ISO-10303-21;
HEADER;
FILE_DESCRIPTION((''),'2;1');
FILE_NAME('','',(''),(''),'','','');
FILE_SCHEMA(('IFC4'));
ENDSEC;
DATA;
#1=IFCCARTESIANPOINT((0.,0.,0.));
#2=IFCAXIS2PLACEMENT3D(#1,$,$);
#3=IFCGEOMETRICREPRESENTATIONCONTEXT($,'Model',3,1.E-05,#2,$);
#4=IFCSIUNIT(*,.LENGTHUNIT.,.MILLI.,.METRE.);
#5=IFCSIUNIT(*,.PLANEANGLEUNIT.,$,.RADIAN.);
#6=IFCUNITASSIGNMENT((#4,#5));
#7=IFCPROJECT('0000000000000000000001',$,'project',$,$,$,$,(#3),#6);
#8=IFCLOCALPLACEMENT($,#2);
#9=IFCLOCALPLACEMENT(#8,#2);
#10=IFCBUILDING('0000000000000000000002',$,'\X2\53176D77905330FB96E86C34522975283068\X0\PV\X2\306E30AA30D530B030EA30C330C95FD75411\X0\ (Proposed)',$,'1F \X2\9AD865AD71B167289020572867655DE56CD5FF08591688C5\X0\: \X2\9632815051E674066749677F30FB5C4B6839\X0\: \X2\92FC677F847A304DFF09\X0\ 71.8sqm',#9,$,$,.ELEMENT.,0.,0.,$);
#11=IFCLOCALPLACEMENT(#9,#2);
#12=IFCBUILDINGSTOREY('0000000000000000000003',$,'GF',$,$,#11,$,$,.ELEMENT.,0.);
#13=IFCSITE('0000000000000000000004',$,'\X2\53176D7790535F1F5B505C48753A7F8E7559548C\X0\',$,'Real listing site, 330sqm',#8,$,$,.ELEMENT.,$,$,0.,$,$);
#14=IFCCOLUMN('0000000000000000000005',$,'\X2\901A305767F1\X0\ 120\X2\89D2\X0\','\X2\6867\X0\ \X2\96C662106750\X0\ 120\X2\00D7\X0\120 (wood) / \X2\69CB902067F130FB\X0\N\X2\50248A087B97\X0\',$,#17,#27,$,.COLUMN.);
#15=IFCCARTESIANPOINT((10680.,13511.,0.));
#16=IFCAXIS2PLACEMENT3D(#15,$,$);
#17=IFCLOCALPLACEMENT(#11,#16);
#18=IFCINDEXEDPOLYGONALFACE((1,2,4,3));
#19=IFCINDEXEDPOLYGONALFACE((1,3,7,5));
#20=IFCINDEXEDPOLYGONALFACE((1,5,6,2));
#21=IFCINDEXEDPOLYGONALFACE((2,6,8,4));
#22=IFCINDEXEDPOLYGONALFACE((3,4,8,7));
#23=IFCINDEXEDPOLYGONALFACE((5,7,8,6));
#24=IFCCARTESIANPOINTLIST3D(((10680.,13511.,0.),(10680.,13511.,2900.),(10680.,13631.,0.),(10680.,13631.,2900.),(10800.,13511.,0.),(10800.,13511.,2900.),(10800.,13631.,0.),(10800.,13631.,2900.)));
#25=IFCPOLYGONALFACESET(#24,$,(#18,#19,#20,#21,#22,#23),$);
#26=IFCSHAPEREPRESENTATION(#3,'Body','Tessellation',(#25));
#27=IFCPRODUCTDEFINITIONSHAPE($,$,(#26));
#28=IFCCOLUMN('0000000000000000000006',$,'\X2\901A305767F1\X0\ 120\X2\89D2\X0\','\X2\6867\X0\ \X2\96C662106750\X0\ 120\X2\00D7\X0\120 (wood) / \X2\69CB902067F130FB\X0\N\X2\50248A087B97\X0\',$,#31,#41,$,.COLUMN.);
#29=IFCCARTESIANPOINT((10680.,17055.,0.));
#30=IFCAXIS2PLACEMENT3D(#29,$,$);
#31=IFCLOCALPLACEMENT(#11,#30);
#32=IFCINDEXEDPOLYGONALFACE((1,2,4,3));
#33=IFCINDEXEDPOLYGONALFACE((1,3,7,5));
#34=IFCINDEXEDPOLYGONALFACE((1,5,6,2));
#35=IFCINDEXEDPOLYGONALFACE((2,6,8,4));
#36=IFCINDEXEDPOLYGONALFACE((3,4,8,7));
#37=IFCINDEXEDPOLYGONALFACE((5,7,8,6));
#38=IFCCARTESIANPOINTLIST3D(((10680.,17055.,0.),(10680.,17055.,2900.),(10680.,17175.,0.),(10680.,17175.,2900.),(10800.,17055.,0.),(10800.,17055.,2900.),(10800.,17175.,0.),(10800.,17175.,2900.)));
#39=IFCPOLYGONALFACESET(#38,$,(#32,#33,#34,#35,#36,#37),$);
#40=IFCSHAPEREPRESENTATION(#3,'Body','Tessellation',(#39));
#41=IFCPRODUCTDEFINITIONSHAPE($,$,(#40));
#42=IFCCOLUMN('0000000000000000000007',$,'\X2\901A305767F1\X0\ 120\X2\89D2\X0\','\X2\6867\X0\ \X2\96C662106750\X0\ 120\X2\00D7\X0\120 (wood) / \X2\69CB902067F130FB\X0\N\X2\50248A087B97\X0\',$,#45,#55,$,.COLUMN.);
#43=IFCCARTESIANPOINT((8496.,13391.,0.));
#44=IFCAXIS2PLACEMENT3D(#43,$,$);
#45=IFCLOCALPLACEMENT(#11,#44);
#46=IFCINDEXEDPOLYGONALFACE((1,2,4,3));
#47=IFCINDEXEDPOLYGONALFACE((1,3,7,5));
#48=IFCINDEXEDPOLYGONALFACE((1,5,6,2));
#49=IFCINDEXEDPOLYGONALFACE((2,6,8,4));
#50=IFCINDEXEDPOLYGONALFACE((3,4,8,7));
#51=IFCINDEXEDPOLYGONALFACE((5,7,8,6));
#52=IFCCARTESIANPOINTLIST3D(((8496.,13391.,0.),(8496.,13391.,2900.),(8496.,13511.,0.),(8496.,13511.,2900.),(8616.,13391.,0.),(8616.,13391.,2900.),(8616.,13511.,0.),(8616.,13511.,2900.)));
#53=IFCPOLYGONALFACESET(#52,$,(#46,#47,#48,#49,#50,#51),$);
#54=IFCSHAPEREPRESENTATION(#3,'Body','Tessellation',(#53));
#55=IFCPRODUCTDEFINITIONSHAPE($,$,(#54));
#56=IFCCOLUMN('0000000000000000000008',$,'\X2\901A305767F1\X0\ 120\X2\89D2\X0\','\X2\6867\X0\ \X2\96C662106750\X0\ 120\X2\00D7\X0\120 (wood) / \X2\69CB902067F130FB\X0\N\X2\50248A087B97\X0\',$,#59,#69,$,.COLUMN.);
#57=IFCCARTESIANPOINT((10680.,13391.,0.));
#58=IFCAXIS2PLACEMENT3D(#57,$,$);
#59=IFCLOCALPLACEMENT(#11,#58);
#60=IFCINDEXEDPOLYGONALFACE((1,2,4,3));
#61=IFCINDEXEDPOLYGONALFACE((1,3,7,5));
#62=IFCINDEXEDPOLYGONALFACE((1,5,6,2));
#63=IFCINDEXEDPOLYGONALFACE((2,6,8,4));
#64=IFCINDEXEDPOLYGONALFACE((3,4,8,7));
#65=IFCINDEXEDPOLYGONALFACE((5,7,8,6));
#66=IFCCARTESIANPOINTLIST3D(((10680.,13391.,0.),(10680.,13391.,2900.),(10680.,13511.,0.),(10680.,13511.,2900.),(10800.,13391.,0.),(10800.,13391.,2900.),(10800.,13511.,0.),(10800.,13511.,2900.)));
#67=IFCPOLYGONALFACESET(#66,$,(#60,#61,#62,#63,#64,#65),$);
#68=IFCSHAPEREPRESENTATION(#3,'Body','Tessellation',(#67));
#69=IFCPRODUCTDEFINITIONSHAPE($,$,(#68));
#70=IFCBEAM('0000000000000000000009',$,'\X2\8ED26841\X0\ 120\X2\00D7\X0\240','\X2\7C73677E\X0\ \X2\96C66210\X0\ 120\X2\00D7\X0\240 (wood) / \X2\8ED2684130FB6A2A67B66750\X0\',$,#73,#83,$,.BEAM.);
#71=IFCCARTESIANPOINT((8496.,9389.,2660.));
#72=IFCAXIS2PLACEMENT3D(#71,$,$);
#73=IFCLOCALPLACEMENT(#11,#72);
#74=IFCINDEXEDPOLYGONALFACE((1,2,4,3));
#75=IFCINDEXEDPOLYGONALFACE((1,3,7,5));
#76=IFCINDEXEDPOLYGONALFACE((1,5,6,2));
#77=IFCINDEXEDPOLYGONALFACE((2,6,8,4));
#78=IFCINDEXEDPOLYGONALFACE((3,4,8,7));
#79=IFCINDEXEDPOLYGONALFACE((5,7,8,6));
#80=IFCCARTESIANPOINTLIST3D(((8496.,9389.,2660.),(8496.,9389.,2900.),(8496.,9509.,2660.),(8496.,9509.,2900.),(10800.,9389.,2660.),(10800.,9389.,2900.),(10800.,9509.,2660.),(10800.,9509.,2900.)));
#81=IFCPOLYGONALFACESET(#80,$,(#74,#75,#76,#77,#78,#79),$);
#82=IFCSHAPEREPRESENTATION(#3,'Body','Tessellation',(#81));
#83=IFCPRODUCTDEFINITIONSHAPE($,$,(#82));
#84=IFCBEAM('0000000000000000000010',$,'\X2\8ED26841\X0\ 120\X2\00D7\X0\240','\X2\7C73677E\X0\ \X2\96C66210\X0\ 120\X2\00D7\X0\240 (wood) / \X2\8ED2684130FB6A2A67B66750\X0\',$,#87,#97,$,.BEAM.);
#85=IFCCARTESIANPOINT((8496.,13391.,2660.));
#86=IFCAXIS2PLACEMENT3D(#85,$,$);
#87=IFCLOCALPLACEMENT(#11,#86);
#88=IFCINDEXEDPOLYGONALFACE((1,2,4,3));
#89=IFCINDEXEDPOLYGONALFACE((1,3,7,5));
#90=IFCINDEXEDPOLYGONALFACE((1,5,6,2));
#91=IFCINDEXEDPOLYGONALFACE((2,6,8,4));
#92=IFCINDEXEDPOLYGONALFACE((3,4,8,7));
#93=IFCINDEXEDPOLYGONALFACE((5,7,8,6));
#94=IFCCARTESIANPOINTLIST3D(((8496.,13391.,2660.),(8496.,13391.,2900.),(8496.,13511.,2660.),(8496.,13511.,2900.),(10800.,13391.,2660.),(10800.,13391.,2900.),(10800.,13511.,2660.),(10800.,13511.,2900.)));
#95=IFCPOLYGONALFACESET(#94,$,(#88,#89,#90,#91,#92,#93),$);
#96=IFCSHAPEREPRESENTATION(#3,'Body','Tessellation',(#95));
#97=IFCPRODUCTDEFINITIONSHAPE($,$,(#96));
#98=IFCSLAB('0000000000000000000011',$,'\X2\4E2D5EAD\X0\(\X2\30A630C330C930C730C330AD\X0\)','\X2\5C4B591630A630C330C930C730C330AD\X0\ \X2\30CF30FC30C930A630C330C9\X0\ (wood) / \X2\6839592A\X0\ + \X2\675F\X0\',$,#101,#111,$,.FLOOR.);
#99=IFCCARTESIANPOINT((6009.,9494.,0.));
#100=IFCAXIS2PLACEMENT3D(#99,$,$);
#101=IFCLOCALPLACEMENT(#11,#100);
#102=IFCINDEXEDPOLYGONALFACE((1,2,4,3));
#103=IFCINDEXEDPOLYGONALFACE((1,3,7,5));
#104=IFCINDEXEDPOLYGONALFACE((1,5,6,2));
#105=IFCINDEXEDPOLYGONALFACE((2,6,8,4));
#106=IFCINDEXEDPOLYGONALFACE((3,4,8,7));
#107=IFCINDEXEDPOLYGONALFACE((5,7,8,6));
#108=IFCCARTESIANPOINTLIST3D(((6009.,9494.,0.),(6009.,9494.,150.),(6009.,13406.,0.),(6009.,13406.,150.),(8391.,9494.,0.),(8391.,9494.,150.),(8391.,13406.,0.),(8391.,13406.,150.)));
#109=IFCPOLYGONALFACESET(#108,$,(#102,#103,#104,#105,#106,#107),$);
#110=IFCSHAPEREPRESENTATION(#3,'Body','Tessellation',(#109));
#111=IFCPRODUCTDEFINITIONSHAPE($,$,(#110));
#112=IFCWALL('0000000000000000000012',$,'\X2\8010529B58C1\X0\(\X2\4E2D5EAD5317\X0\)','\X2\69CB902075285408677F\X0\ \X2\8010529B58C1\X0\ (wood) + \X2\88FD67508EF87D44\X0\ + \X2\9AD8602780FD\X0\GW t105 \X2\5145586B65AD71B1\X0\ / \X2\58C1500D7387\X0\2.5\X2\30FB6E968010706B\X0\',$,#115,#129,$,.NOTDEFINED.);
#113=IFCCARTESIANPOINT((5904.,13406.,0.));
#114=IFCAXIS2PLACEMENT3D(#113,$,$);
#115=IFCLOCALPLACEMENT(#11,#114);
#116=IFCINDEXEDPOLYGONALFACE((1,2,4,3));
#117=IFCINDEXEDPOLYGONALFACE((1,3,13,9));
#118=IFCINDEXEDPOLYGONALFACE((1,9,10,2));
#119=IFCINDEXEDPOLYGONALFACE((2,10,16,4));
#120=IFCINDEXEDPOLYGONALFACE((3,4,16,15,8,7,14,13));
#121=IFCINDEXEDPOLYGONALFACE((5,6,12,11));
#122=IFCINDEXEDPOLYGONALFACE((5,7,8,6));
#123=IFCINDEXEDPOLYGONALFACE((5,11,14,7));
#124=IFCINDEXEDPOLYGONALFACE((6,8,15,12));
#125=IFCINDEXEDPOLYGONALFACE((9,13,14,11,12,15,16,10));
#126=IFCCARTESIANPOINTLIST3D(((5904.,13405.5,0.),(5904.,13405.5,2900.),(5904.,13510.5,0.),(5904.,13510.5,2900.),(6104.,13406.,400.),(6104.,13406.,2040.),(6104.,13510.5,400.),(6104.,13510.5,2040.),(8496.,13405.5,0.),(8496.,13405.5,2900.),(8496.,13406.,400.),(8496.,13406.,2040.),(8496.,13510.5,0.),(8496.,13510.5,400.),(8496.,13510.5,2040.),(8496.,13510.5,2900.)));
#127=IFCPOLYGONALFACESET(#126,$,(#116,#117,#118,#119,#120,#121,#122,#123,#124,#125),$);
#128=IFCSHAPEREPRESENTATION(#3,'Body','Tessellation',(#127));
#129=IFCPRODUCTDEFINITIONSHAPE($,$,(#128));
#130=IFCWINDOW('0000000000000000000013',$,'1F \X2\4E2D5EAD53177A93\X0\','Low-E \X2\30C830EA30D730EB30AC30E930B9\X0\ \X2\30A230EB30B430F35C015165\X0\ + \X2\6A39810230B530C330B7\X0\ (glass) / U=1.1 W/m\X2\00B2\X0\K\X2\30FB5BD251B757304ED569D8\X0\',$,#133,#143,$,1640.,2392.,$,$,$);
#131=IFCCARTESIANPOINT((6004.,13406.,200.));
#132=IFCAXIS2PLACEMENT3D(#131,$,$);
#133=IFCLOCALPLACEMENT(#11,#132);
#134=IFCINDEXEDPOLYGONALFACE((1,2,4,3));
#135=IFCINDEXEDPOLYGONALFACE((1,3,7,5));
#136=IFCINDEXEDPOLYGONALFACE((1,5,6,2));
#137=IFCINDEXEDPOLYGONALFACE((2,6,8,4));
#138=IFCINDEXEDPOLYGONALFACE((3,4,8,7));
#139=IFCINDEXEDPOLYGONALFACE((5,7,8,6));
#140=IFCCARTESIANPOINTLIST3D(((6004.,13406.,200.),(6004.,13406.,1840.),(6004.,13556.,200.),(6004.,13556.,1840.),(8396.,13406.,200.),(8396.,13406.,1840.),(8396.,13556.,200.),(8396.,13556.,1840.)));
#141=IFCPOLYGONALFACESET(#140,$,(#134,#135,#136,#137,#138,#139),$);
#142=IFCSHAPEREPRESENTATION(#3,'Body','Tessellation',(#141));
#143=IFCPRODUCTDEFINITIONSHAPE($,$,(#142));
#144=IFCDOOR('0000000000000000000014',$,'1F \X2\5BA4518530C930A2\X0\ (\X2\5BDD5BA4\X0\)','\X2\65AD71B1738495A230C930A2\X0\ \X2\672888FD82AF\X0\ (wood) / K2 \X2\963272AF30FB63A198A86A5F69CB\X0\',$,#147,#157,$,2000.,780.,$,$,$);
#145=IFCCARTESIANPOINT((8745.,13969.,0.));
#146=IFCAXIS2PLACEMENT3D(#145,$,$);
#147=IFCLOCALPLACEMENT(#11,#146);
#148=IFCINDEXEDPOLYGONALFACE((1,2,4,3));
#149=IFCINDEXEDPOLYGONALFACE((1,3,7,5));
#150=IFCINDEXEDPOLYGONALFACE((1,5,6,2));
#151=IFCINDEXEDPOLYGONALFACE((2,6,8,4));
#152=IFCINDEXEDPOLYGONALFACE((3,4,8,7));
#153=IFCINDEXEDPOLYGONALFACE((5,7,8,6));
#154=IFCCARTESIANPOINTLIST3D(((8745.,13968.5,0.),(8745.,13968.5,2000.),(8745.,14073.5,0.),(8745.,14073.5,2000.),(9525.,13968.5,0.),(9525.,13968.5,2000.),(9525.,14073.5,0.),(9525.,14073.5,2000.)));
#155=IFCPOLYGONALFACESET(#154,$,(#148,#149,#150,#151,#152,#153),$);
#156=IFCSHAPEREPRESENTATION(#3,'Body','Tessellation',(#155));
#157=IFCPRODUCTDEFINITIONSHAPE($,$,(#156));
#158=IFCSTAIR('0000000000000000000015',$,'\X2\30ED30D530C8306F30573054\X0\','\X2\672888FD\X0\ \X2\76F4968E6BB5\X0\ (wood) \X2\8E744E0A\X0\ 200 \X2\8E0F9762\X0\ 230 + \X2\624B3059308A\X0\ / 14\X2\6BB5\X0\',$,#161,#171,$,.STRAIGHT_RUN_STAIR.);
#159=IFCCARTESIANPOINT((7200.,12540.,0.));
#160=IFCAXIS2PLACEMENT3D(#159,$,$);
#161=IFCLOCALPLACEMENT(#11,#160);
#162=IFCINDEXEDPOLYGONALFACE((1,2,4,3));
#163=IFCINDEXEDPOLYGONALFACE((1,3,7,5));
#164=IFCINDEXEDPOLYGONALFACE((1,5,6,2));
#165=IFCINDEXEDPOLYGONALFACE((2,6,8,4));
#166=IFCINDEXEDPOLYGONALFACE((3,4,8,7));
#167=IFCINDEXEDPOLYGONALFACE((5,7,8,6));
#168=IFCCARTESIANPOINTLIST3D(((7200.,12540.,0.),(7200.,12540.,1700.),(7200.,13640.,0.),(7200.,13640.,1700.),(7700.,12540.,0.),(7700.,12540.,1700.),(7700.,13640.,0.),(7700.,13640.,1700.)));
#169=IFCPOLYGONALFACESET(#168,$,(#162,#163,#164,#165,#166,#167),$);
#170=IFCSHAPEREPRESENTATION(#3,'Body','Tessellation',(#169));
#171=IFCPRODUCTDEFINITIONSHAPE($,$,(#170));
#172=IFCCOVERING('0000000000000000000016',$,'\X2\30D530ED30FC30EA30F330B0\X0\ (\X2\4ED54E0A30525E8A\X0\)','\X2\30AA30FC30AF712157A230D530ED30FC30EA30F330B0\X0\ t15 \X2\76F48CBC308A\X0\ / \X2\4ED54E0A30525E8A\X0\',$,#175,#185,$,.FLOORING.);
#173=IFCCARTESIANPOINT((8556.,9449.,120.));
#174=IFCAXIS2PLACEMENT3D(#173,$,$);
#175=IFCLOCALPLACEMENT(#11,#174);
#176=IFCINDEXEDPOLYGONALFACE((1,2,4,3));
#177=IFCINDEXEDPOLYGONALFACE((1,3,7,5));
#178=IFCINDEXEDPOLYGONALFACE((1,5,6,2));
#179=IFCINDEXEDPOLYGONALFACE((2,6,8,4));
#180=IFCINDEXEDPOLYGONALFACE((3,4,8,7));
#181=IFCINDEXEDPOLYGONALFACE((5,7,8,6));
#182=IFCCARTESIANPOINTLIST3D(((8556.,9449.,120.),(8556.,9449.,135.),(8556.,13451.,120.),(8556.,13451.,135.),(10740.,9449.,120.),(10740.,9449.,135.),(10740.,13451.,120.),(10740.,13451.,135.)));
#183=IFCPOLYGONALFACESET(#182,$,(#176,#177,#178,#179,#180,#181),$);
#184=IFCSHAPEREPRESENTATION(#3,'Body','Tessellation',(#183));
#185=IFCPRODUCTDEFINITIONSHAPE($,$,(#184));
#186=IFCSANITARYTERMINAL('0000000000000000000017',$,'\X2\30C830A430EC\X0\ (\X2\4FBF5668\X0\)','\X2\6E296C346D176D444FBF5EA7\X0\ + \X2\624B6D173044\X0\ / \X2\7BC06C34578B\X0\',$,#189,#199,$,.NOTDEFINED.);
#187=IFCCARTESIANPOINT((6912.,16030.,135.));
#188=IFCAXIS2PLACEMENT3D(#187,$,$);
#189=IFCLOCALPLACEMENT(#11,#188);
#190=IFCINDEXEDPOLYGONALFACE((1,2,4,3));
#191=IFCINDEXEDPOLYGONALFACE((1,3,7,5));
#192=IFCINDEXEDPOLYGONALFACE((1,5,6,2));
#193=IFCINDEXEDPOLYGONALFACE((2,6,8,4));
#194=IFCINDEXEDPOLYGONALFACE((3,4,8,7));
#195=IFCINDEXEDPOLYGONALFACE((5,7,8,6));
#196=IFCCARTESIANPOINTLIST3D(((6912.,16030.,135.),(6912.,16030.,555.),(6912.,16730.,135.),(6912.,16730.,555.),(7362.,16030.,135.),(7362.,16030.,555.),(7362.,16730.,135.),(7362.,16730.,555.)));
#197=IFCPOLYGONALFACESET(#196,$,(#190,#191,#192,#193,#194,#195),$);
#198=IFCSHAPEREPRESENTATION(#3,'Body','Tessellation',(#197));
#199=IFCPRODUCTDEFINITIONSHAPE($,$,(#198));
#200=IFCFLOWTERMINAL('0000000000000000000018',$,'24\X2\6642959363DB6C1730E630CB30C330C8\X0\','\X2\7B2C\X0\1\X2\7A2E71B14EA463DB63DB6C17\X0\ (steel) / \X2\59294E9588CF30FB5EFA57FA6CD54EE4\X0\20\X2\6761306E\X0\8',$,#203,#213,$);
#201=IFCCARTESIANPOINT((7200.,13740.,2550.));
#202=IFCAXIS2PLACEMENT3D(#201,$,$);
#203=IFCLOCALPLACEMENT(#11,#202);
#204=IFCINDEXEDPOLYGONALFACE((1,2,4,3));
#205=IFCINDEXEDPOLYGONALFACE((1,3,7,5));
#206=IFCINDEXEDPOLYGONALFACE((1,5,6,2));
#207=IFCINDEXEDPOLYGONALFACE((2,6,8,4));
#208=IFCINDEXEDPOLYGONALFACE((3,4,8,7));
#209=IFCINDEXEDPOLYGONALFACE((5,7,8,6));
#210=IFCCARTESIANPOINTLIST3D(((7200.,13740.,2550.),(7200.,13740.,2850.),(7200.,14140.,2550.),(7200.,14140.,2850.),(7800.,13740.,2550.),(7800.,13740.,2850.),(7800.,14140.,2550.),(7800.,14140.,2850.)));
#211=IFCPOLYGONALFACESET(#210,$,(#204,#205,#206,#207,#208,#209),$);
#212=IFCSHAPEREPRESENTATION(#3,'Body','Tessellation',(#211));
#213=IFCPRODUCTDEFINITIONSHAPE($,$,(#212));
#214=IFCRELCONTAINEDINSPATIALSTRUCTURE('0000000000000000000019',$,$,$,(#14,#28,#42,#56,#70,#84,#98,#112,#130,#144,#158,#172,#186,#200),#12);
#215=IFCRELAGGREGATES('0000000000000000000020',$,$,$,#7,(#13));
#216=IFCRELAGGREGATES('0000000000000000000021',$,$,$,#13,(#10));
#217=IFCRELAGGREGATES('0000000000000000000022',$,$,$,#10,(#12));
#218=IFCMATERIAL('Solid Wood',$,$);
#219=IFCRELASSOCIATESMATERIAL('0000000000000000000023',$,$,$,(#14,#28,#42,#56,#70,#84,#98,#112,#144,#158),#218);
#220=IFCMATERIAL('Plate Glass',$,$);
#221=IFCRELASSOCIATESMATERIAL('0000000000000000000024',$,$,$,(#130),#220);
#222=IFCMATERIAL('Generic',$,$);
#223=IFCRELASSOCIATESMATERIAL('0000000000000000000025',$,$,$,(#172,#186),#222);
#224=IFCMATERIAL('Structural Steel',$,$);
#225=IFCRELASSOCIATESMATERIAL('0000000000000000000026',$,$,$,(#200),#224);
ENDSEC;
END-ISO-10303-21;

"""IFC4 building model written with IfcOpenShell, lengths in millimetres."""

from ifc_helpers import new_model, si_unit, frame, frame_2d, origin, place, context, project, spatial, rectangle, extrude, material, element, fill, save


model = new_model("IFC4")

# Units and contexts
model_context = context("Model", 3, precision=1e-05, world=origin())
ifc_project = project(units=[si_unit("LENGTHUNIT", "METRE", prefix="MILLI"), si_unit("PLANEANGLEUNIT", "RADIAN")], contexts=[model_context])

# Site, building, storey
site_placement = place(None, origin())
site = spatial("IfcSite", under=ifc_project, at=site_placement, Name="北海道弟子屈町美留和", ObjectType="Real listing site, 330sqm", CompositionType="ELEMENT", RefElevation=0.0)
building_placement = place(site_placement, origin())
building = spatial("IfcBuilding", under=site, at=building_placement, Name="北海道・雨水利用とPVのオフグリッド志向 (Proposed)", ObjectType="1F 高断熱木造在来工法（外装: 防腐処理杉板・屋根: 鋼板葺き） 71.8sqm", CompositionType="ELEMENT", ElevationOfRefHeight=0.0, ElevationOfTerrain=0.0)
storey_placement = place(building_placement, origin())
storey = spatial("IfcBuildingStorey", under=building, at=storey_placement, Name="GF", CompositionType="ELEMENT", Elevation=0.0)

# Columns
ifc_material_1 = material(Name="Solid Wood")
column_1_placement = place(storey_placement, frame((10680.0, 13511.0, 0.0)))
element("IfcColumn", 1, at=column_1_placement, inside=storey, material=ifc_material_1, Name="通し柱 120角", Description="桧 集成材 120×120 (wood) / 構造柱・N値計算", PredefinedType="COLUMN", context=model_context, shape_type="SweptSolid", body=[
    extrude(rectangle(XDim=120.0, YDim=120.0, at=frame_2d((60.0, 60.0))), frame((10680.0, 13511.0, 0.0)), (0.0, 0.0, 1.0), 2900.0),
])
column_2_placement = place(storey_placement, frame((10680.0, 17055.0, 0.0)))
element("IfcColumn", 2, at=column_2_placement, inside=storey, material=ifc_material_1, Name="通し柱 120角", Description="桧 集成材 120×120 (wood) / 構造柱・N値計算", PredefinedType="COLUMN", context=model_context, shape_type="SweptSolid", body=[
    extrude(rectangle(XDim=120.0, YDim=120.0, at=frame_2d((60.0, 60.0))), frame((10680.0, 17055.0, 0.0)), (0.0, 0.0, 1.0), 2900.0),
])
column_3_placement = place(storey_placement, frame((8496.0, 13391.0, 0.0)))
element("IfcColumn", 3, at=column_3_placement, inside=storey, material=ifc_material_1, Name="通し柱 120角", Description="桧 集成材 120×120 (wood) / 構造柱・N値計算", PredefinedType="COLUMN", context=model_context, shape_type="SweptSolid", body=[
    extrude(rectangle(XDim=120.0, YDim=120.0, at=frame_2d((60.0, 60.0))), frame((8496.0, 13391.0, 0.0)), (0.0, 0.0, 1.0), 2900.0),
])
column_4_placement = place(storey_placement, frame((10680.0, 13391.0, 0.0)))
element("IfcColumn", 4, at=column_4_placement, inside=storey, material=ifc_material_1, Name="通し柱 120角", Description="桧 集成材 120×120 (wood) / 構造柱・N値計算", PredefinedType="COLUMN", context=model_context, shape_type="SweptSolid", body=[
    extrude(rectangle(XDim=120.0, YDim=120.0, at=frame_2d((60.0, 60.0))), frame((10680.0, 13391.0, 0.0)), (0.0, 0.0, 1.0), 2900.0),
])

# Beams
beam_1_placement = place(storey_placement, frame((8496.0, 9389.0, 2660.0)))
element("IfcBeam", 5, at=beam_1_placement, inside=storey, material=ifc_material_1, Name="軒桁 120×240", Description="米松 集成 120×240 (wood) / 軒桁・横架材", PredefinedType="BEAM", context=model_context, shape_type="SweptSolid", body=[
    extrude(rectangle(XDim=2304.0, YDim=120.0, at=frame_2d((1152.0, 60.0))), frame((8496.0, 9389.0, 2660.0)), (0.0, 0.0, 1.0), 240.0),
])
beam_2_placement = place(storey_placement, frame((8496.0, 13391.0, 2660.0)))
element("IfcBeam", 6, at=beam_2_placement, inside=storey, material=ifc_material_1, Name="軒桁 120×240", Description="米松 集成 120×240 (wood) / 軒桁・横架材", PredefinedType="BEAM", context=model_context, shape_type="SweptSolid", body=[
    extrude(rectangle(XDim=2304.0, YDim=120.0, at=frame_2d((1152.0, 60.0))), frame((8496.0, 13391.0, 2660.0)), (0.0, 0.0, 1.0), 240.0),
])

# Slab
slab_placement = place(storey_placement, frame((6009.0, 9494.0, 0.0)))
element("IfcSlab", 7, at=slab_placement, inside=storey, material=ifc_material_1, Name="中庭(ウッドデッキ)", Description="屋外ウッドデッキ ハードウッド (wood) / 根太 + 束", PredefinedType="FLOOR", context=model_context, shape_type="SweptSolid", body=[
    extrude(rectangle(XDim=2382.0, YDim=3912.0, at=frame_2d((1191.0, 1956.0))), frame((6009.0, 9494.0, 0.0)), (0.0, 0.0, 1.0), 150.0),
])

# Wall, opening, window
wall_1_placement = place(storey_placement, frame((5904.0, 13406.0, 0.0)))
wall_1 = element("IfcWall", 8, at=wall_1_placement, inside=storey, material=ifc_material_1, Name="耐力壁(中庭北)", Description="構造用合板 耐力壁 (wood) + 製材軸組 + 高性能GW t105 充填断熱 / 壁倍率2.5・準耐火", PredefinedType="NOTDEFINED", context=model_context, shape_type="SweptSolid", body=[
    extrude(rectangle(XDim=2592.0, YDim=105.0, at=frame_2d((1296.0, 52.0))), frame((5904.0, 13406.0, 0.0)), (0.0, 0.0, 1.0), 2900.0),
])
opening_placement = place(storey_placement, frame((6004.0, 13406.0, 200.0)))
opening = element("IfcOpeningElement", 9, at=opening_placement, cuts=wall_1, PredefinedType="NOTDEFINED", context=model_context, shape_type="SweptSolid", body=[
    extrude(rectangle(XDim=2392.0, YDim=150.0, at=frame_2d((1196.0, 75.0))), frame((6004.0, 13406.0, 200.0)), (0.0, 0.0, 1.0), 1640.0),
])
ifc_material_2 = material(Name="Plate Glass")
window_placement = place(storey_placement, frame((6004.0, 13406.0, 200.0)))
window = element("IfcWindow", 10, at=window_placement, inside=storey, material=ifc_material_2, Name="1F 中庭北窓", Description="Low-E トリプルガラス アルゴン封入 + 樹脂サッシ (glass) / U=1.1 W/m²K・寒冷地仕様", OverallHeight=1640.0, OverallWidth=2392.0, context=model_context, shape_type="SweptSolid", body=[
    extrude(rectangle(XDim=2392.0, YDim=150.0, at=frame_2d((1196.0, 75.0))), frame((6004.0, 13406.0, 200.0)), (0.0, 0.0, 1.0), 1640.0),
])
fill(opening, window)

# Door
door_placement = place(storey_placement, frame((8745.0, 13969.0, 0.0)))
element("IfcDoor", 11, at=door_placement, inside=storey, material=ifc_material_1, Name="1F 室内ドア (寝室)", Description="断熱玄関ドア 木製芯 (wood) / K2 防犯・採風機構", OverallHeight=2000.0, OverallWidth=780.0, context=model_context, shape_type="SweptSolid", body=[
    extrude(rectangle(XDim=780.0, YDim=105.0, at=frame_2d((390.0, 52.0))), frame((8745.0, 13969.0, 0.0)), (0.0, 0.0, 1.0), 2000.0),
])

# Stair
stair_placement = place(storey_placement, frame((7200.0, 12540.0, 0.0)))
element("IfcStair", 12, at=stair_placement, inside=storey, material=ifc_material_1, Name="ロフトはしご", Description="木製 直階段 (wood) 蹴上 200 踏面 230 + 手すり / 14段", PredefinedType="STRAIGHT_RUN_STAIR", context=model_context, shape_type="SweptSolid", body=[
    extrude(rectangle(XDim=500.0, YDim=1100.0, at=frame_2d((250.0, 550.0))), frame((7200.0, 12540.0, 0.0)), (0.0, 0.0, 1.0), 1700.0),
])

# Covering
ifc_material_3 = material(Name="Generic")
covering_placement = place(storey_placement, frame((8556.0, 9449.0, 120.0)))
element("IfcCovering", 13, at=covering_placement, inside=storey, material=ifc_material_3, Name="フローリング (仕上げ床)", Description="オーク無垢フローリング t15 直貼り / 仕上げ床", PredefinedType="FLOORING", context=model_context, shape_type="SweptSolid", body=[
    extrude(rectangle(XDim=2184.0, YDim=4002.0, at=frame_2d((1092.0, 2001.0))), frame((8556.0, 9449.0, 120.0)), (0.0, 0.0, 1.0), 15.0),
])

# Sanitary terminal
sanitary_terminal_placement = place(storey_placement, frame((6912.0, 16030.0, 135.0)))
element("IfcSanitaryTerminal", 14, at=sanitary_terminal_placement, inside=storey, material=ifc_material_3, Name="トイレ (便器)", Description="温水洗浄便座 + 手洗い / 節水型", PredefinedType="NOTDEFINED", context=model_context, shape_type="SweptSolid", body=[
    extrude(rectangle(XDim=450.0, YDim=700.0, at=frame_2d((225.0, 350.0))), frame((6912.0, 16030.0, 135.0)), (0.0, 0.0, 1.0), 420.0),
])

# Flow terminal
ifc_material_4 = material(Name="Structural Steel")
flow_terminal_placement = place(storey_placement, frame((7200.0, 13740.0, 2550.0)))
element("IfcFlowTerminal", 15, at=flow_terminal_placement, inside=storey, material=ifc_material_4, Name="24時間換気ユニット", Description="第1種熱交換換気 (steel) / 天井裏・建基法令20条の8", context=model_context, shape_type="SweptSolid", body=[
    extrude(rectangle(XDim=600.0, YDim=400.0, at=frame_2d((300.0, 200.0))), frame((7200.0, 13740.0, 2550.0)), (0.0, 0.0, 1.0), 300.0),
])

save(model, "model.ifc")
